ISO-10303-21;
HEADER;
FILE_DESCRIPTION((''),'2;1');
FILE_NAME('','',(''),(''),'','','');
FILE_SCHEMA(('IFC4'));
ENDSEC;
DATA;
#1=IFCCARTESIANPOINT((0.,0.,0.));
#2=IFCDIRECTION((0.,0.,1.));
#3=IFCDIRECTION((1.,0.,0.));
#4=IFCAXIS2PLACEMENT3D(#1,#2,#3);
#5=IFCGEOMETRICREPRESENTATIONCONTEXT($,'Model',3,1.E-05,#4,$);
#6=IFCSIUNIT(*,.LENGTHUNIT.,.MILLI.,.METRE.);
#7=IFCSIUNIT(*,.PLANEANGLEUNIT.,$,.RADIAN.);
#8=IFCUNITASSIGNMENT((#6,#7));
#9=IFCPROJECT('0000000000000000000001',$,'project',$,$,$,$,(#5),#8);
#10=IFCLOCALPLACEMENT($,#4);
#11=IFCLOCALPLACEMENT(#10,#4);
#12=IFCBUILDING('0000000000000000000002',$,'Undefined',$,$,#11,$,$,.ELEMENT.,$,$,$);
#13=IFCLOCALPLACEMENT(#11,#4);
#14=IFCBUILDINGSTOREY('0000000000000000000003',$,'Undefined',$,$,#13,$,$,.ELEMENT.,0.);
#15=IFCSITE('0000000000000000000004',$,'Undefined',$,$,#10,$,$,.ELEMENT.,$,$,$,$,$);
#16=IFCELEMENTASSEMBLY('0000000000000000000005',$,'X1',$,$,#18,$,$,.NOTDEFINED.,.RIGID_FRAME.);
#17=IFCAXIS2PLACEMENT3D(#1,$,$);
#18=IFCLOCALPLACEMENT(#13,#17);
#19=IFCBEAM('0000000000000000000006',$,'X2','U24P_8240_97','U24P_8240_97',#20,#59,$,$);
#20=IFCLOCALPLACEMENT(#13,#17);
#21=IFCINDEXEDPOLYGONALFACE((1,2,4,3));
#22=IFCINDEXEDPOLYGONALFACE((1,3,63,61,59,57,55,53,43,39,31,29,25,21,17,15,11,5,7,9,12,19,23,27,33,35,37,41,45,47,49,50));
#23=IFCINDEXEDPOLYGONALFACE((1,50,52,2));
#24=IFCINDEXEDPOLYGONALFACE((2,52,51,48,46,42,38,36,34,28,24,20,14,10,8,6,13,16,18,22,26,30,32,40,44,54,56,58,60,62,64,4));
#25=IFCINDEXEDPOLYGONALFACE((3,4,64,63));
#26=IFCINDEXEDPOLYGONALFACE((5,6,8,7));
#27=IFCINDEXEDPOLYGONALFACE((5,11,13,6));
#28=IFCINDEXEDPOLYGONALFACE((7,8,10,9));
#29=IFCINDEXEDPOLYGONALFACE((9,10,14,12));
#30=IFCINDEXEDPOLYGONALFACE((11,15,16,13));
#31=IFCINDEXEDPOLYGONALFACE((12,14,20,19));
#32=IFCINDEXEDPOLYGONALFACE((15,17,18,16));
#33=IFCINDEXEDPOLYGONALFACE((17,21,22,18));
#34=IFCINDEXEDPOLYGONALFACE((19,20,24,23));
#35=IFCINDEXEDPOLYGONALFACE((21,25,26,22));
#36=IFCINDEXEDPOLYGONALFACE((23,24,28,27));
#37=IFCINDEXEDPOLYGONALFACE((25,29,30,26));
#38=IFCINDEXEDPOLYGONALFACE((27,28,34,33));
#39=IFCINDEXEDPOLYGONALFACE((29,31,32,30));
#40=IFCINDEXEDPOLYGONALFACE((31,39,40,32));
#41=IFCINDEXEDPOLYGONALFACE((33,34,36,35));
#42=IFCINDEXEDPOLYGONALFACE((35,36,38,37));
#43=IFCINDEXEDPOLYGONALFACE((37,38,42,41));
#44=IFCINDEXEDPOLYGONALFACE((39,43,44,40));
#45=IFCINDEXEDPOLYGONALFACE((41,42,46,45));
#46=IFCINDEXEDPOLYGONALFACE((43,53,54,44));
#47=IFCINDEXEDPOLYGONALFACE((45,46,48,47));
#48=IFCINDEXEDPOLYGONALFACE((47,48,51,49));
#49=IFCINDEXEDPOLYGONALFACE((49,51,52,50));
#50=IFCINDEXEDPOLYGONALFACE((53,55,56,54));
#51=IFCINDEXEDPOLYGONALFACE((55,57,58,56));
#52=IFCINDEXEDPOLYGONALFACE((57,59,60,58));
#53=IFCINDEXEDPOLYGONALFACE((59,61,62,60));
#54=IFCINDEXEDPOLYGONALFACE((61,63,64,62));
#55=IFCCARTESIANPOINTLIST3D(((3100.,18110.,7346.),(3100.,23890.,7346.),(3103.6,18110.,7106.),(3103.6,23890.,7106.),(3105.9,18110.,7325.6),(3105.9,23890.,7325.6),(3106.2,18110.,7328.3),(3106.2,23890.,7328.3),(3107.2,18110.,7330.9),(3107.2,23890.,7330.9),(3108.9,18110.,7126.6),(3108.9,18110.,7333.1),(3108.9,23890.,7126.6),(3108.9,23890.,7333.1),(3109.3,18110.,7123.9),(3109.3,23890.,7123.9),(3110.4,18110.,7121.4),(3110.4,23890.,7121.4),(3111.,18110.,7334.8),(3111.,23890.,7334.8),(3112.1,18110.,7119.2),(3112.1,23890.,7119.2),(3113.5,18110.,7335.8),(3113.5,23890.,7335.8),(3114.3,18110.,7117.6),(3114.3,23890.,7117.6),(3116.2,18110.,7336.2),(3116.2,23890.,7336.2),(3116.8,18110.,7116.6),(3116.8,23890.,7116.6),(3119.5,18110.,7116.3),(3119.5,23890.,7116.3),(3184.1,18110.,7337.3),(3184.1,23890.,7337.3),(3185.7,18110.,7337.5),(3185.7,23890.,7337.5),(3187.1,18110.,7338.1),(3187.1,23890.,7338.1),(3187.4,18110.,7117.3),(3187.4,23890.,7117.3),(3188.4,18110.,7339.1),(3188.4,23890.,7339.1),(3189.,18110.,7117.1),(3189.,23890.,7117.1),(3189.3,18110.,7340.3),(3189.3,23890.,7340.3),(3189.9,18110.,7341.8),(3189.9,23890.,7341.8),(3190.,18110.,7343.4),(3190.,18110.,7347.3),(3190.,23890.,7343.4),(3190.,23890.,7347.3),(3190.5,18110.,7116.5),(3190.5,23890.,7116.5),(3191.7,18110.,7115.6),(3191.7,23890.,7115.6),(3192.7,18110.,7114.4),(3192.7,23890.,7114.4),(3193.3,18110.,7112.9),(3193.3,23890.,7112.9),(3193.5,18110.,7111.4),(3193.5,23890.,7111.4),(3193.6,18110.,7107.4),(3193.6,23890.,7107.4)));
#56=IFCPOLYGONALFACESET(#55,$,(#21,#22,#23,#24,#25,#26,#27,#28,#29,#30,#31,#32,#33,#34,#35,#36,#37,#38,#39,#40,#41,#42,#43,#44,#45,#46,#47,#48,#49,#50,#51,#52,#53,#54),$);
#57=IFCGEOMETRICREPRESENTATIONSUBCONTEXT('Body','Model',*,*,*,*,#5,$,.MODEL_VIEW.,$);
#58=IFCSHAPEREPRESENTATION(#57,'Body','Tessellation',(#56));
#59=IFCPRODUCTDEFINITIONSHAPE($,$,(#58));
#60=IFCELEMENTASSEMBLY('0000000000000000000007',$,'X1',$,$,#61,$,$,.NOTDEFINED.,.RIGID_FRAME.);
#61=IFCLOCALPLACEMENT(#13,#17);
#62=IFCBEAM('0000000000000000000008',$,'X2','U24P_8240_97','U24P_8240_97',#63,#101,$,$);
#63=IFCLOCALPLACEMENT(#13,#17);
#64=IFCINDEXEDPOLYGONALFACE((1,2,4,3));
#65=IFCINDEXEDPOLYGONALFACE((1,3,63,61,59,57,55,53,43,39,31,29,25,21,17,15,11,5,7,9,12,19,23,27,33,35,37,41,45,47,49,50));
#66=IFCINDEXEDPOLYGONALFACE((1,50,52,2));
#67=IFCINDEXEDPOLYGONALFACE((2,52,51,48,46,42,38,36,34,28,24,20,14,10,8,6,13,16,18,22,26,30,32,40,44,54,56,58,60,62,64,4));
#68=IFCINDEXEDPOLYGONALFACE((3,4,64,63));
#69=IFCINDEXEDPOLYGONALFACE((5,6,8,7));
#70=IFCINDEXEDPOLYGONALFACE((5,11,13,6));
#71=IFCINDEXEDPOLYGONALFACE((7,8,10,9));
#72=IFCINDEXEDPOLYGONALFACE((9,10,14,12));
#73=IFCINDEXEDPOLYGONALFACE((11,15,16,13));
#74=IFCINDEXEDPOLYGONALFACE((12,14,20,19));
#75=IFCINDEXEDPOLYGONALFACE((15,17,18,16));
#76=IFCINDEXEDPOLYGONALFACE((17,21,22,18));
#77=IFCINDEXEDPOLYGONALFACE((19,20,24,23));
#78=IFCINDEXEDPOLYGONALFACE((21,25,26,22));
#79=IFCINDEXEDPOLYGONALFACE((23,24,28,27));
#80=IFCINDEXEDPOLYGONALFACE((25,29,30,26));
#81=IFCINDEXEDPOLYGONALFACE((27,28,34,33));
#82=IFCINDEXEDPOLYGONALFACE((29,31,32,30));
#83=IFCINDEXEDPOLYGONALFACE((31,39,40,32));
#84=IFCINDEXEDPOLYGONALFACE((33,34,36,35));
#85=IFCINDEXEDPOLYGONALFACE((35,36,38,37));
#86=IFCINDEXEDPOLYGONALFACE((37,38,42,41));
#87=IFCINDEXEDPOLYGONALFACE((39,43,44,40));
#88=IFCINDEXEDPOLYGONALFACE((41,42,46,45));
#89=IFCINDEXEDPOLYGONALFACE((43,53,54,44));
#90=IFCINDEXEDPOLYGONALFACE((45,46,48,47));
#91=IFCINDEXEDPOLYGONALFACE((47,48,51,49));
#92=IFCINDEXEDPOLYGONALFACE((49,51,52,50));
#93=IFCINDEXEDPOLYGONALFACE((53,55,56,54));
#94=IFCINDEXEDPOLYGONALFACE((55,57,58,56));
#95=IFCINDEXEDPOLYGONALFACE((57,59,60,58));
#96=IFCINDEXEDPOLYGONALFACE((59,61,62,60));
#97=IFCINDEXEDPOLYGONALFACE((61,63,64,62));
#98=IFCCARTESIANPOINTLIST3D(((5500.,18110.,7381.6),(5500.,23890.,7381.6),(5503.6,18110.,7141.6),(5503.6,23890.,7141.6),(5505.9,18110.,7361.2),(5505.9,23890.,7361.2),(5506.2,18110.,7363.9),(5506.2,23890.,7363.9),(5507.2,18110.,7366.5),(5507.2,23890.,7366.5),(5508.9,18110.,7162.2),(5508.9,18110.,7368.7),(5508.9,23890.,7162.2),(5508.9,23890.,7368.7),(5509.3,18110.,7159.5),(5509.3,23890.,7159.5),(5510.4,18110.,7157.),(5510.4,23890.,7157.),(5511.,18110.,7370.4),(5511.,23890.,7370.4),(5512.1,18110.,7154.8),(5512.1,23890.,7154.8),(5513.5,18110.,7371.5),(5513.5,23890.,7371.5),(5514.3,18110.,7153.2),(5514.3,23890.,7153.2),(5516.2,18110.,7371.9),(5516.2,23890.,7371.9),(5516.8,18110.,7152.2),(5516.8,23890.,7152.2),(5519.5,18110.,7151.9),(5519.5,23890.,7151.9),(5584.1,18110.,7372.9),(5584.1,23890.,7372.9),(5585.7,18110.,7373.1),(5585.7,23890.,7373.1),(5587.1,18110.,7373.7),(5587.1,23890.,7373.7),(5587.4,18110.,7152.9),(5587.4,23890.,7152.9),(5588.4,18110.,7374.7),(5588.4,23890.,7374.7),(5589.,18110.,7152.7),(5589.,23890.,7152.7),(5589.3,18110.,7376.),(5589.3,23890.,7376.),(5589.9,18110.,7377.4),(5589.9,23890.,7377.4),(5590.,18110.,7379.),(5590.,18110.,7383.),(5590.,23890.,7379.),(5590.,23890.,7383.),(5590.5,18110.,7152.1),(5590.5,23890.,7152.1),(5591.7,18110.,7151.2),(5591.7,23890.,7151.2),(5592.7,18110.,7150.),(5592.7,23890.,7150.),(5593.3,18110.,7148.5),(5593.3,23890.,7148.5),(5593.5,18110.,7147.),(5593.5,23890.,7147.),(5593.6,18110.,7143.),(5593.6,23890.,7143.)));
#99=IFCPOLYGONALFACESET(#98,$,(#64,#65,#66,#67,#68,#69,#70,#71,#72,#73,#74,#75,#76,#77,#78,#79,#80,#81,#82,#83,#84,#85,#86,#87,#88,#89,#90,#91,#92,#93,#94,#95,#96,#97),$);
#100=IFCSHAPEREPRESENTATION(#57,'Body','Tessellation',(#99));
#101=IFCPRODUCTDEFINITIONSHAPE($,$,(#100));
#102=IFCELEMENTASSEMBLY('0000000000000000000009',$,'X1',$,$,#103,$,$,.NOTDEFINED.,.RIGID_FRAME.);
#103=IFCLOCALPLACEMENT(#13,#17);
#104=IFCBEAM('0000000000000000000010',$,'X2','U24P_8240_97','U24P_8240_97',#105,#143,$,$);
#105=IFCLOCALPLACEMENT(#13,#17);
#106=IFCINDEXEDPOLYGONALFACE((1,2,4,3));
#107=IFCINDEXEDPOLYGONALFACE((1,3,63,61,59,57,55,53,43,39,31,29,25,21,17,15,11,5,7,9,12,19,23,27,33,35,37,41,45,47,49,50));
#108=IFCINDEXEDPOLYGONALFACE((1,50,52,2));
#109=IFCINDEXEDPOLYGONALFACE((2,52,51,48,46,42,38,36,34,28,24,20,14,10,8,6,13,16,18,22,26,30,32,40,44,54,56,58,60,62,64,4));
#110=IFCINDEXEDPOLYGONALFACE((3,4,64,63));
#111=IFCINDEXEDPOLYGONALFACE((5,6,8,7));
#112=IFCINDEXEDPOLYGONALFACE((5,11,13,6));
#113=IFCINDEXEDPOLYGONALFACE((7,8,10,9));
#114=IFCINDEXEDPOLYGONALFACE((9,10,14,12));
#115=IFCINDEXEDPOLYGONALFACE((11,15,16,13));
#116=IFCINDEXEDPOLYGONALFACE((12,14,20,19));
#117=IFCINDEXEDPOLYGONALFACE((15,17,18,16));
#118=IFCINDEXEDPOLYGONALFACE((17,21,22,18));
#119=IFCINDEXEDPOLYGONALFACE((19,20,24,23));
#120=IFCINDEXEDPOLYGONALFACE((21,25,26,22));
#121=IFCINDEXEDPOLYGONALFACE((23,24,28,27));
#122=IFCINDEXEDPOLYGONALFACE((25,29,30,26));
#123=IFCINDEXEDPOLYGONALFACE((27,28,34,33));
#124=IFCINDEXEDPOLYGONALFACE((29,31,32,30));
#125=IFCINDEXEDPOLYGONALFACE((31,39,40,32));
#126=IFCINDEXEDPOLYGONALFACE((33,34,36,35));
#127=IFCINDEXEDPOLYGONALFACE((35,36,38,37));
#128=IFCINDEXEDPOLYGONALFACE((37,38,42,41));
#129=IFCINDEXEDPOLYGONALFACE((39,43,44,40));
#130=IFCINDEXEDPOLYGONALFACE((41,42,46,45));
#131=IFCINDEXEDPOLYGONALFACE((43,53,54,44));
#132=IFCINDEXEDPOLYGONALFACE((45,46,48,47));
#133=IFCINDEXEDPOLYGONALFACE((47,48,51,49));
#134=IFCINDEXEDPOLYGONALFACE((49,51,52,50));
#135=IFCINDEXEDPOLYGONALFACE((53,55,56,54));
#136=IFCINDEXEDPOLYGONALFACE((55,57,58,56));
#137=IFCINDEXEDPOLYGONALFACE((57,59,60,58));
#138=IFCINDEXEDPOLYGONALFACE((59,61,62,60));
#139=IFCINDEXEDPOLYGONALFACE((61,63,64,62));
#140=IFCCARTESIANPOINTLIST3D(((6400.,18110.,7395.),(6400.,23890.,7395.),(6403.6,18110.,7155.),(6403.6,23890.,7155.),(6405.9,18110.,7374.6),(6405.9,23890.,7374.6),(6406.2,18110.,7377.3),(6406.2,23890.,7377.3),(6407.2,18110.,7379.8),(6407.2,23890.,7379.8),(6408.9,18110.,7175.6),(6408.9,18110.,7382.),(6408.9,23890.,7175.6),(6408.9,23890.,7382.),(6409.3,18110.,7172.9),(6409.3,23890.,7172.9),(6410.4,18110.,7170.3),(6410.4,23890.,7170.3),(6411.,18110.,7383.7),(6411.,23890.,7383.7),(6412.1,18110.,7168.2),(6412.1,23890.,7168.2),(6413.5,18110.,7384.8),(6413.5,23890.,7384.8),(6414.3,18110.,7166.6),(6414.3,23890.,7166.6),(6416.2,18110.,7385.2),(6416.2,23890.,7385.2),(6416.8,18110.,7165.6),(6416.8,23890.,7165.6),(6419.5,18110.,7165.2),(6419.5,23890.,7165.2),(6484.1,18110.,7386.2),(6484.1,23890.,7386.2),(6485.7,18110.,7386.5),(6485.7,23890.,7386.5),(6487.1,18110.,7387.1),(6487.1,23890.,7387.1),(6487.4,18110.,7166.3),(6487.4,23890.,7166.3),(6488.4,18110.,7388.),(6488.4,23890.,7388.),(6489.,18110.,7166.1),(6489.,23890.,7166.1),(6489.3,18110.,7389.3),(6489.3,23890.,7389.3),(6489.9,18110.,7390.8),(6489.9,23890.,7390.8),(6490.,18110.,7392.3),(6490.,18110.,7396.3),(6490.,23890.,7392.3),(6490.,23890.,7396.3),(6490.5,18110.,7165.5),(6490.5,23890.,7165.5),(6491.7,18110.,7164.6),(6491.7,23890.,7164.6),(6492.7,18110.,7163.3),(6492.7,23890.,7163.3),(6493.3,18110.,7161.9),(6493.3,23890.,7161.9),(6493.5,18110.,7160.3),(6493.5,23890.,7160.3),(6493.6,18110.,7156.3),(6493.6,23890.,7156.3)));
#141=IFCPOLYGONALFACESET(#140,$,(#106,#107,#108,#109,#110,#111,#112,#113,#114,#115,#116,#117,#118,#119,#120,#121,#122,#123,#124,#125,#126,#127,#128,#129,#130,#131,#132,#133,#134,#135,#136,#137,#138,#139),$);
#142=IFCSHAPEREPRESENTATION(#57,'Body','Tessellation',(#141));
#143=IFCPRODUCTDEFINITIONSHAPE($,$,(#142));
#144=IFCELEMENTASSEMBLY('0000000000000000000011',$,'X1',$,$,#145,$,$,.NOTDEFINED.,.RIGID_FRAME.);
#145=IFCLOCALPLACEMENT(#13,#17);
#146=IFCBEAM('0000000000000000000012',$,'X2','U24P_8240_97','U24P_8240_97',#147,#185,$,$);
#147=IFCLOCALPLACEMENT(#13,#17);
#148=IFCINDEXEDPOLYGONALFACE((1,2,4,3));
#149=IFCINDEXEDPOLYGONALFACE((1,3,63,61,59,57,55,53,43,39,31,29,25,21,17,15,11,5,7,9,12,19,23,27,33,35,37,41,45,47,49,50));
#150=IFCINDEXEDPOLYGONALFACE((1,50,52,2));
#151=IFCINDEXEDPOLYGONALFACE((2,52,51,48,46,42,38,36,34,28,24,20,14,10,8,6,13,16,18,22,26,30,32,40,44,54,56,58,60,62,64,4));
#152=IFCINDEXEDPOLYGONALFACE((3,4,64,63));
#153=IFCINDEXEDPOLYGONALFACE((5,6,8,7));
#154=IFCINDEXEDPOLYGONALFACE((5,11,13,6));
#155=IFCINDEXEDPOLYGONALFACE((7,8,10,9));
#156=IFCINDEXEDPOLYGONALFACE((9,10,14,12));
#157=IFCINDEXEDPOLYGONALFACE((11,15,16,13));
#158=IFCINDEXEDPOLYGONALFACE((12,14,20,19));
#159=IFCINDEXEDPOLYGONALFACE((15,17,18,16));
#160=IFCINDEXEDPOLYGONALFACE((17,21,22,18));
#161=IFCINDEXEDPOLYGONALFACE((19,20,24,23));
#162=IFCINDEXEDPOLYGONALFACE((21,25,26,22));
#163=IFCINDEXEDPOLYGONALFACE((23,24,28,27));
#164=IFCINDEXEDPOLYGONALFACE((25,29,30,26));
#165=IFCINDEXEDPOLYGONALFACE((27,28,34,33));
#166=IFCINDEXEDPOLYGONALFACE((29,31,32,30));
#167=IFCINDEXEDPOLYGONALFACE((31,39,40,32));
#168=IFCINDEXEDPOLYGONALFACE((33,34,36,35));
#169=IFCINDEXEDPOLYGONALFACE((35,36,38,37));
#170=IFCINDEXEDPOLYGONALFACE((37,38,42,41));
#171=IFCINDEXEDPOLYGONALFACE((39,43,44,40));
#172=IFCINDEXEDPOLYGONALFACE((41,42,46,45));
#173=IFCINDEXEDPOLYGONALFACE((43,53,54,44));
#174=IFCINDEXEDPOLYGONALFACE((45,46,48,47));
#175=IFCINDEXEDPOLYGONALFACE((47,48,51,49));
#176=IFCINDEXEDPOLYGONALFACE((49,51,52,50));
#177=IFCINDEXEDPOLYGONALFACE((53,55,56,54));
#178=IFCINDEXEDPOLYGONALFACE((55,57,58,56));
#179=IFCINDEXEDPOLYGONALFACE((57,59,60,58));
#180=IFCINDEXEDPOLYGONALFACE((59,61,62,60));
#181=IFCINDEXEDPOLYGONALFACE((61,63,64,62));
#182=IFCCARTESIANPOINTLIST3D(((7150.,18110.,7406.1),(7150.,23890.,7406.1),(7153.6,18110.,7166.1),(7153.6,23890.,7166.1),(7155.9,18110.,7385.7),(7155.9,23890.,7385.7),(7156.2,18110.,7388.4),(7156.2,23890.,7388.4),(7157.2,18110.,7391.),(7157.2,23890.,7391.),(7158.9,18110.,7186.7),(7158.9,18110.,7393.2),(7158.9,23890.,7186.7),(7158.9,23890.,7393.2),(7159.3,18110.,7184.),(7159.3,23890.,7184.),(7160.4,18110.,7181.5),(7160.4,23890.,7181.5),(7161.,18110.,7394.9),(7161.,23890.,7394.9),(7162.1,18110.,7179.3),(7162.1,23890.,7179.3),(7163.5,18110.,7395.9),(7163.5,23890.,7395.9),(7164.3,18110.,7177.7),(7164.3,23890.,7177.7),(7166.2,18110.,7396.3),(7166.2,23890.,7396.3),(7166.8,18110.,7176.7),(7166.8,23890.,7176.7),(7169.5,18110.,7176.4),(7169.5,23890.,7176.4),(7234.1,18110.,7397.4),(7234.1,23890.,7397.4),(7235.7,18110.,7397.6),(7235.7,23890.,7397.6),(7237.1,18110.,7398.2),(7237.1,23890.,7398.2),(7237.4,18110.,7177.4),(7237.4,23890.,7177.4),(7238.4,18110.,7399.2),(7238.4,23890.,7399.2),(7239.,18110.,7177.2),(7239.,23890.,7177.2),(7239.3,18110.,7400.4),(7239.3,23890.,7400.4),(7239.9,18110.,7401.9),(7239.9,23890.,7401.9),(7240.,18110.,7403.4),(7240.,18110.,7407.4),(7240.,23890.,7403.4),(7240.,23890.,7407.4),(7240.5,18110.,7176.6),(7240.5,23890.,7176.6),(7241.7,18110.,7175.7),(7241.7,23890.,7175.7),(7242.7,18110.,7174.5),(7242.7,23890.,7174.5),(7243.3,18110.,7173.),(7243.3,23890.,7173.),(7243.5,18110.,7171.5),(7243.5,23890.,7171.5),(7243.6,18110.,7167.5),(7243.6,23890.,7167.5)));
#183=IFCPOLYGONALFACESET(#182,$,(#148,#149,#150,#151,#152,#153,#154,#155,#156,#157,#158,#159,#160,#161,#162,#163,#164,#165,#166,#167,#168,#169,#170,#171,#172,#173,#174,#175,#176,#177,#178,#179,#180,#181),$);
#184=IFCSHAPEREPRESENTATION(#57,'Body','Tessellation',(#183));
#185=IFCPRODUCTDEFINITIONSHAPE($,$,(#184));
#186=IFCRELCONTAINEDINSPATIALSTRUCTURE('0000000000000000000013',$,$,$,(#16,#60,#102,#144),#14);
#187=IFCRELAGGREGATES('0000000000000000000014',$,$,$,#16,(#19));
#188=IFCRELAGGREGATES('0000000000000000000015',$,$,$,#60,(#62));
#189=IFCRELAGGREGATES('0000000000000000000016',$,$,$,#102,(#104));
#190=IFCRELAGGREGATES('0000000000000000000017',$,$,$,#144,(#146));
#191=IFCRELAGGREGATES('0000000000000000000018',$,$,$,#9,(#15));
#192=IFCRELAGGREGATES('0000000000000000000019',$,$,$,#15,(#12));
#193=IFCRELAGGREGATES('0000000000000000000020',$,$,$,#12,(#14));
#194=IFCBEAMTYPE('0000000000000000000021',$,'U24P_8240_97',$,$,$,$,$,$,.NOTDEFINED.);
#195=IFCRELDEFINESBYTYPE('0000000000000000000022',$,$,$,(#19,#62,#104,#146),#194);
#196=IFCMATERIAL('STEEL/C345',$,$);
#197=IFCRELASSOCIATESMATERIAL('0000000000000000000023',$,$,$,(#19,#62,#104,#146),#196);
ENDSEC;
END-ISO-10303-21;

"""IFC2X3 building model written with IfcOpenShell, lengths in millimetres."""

from ifc_helpers import new_model, si_unit, frame, origin_with_axes, origin_2d_with_axis, place, context, subcontext, project, spatial, u_section, extrude, material, type_object, element, aggregate, save


model = new_model("IFC2X3")

# Units and contexts
model_context = context("Model", 3, precision=1e-05, world=origin_with_axes())
body_context = subcontext(model_context, "Body", "Model", "MODEL_VIEW")
ifc_project = project(units=[si_unit("LENGTHUNIT", "METRE", prefix="MILLI"), si_unit("PLANEANGLEUNIT", "RADIAN")], contexts=[model_context])

# Site, building, storey
site_placement = place(None, origin_with_axes())
site = spatial("IfcSite", under=ifc_project, at=site_placement, Name="Undefined", CompositionType="ELEMENT")
building_placement = place(site_placement, origin_with_axes())
building = spatial("IfcBuilding", under=site, at=building_placement, Name="Undefined", CompositionType="ELEMENT")
storey_placement = place(building_placement, origin_with_axes())
storey = spatial("IfcBuildingStorey", under=building, at=storey_placement, Name="Undefined", CompositionType="ELEMENT", Elevation=0.0)

# Element assemblies, beams
ifc_material_1 = material(Name="STEEL/C345")
beam_type_1 = type_object("IfcBeamType", Name="U24P_8240_97", PredefinedType="NOTDEFINED")
assembly_1_placement = place(storey_placement, origin_with_axes())
assembly_1 = element("IfcElementAssembly", 1, at=assembly_1_placement, inside=storey, Name="X1", AssemblyPlace="NOTDEFINED", PredefinedType="RIGID_FRAME")
beam_1_placement = place(assembly_1_placement, frame((3146.8, 23890.0, 7226.7), z_axis=(0.014998, 0.0, -0.999888), x_axis=(0.0, -1.0, 0.0)))
beam_1 = element("IfcBeam", 2, at=beam_1_placement, type_object=beam_type_1, material=ifc_material_1, Name="X2", Description="U24P_8240_97", ObjectType="U24P_8240_97", context=body_context, shape_type="SweptSolid", body=[
    extrude(u_section(Depth=240.0, FlangeWidth=90.0, WebThickness=5.6, FlangeThickness=10.0, FilletRadius=10.5, EdgeRadius=6.0, at=origin_2d_with_axis()), frame((5780.0, 0.0, 0.0), z_axis=(-1.0, 0.0, 0.0), x_axis=(0.0, -1.0, 0.0)), (0.0, 0.0, 1.0), 5780.0),
])
aggregate(assembly_1, [beam_1])
assembly_2_placement = place(storey_placement, origin_with_axes())
assembly_2 = element("IfcElementAssembly", 3, at=assembly_2_placement, inside=storey, Name="X1", AssemblyPlace="NOTDEFINED", PredefinedType="RIGID_FRAME")
beam_2_placement = place(assembly_2_placement, frame((5546.8, 23890.0, 7262.3), z_axis=(0.014998, 0.0, -0.999888), x_axis=(0.0, -1.0, 0.0)))
beam_2 = element("IfcBeam", 4, at=beam_2_placement, type_object=beam_type_1, material=ifc_material_1, Name="X2", Description="U24P_8240_97", ObjectType="U24P_8240_97", context=body_context, shape_type="SweptSolid", body=[
    extrude(u_section(Depth=240.0, FlangeWidth=90.0, WebThickness=5.6, FlangeThickness=10.0, FilletRadius=10.5, EdgeRadius=6.0, at=origin_2d_with_axis()), frame((5780.0, 0.0, 0.0), z_axis=(-1.0, 0.0, 0.0), x_axis=(0.0, -1.0, 0.0)), (0.0, 0.0, 1.0), 5780.0),
])
aggregate(assembly_2, [beam_2])
assembly_3_placement = place(storey_placement, origin_with_axes())
assembly_3 = element("IfcElementAssembly", 5, at=assembly_3_placement, inside=storey, Name="X1", AssemblyPlace="NOTDEFINED", PredefinedType="RIGID_FRAME")
beam_3_placement = place(assembly_3_placement, frame((6446.8, 23890.0, 7275.7), z_axis=(0.014998, 0.0, -0.999888), x_axis=(0.0, -1.0, 0.0)))
beam_3 = element("IfcBeam", 6, at=beam_3_placement, type_object=beam_type_1, material=ifc_material_1, Name="X2", Description="U24P_8240_97", ObjectType="U24P_8240_97", context=body_context, shape_type="SweptSolid", body=[
    extrude(u_section(Depth=240.0, FlangeWidth=90.0, WebThickness=5.6, FlangeThickness=10.0, FilletRadius=10.5, EdgeRadius=6.0, at=origin_2d_with_axis()), frame((5780.0, 0.0, 0.0), z_axis=(-1.0, 0.0, 0.0), x_axis=(0.0, -1.0, 0.0)), (0.0, 0.0, 1.0), 5780.0),
])
aggregate(assembly_3, [beam_3])
assembly_4_placement = place(storey_placement, origin_with_axes())
assembly_4 = element("IfcElementAssembly", 7, at=assembly_4_placement, inside=storey, Name="X1", AssemblyPlace="NOTDEFINED", PredefinedType="RIGID_FRAME")
beam_4_placement = place(assembly_4_placement, frame((7196.8, 23890.0, 7286.8), z_axis=(0.014998, 0.0, -0.999888), x_axis=(0.0, -1.0, 0.0)))
beam_4 = element("IfcBeam", 8, at=beam_4_placement, type_object=beam_type_1, material=ifc_material_1, Name="X2", Description="U24P_8240_97", ObjectType="U24P_8240_97", context=body_context, shape_type="SweptSolid", body=[
    extrude(u_section(Depth=240.0, FlangeWidth=90.0, WebThickness=5.6, FlangeThickness=10.0, FilletRadius=10.5, EdgeRadius=6.0, at=origin_2d_with_axis()), frame((5780.0, 0.0, 0.0), z_axis=(-1.0, 0.0, 0.0), x_axis=(0.0, -1.0, 0.0)), (0.0, 0.0, 1.0), 5780.0),
])
aggregate(assembly_4, [beam_4])

save(model, "model.ifc")
